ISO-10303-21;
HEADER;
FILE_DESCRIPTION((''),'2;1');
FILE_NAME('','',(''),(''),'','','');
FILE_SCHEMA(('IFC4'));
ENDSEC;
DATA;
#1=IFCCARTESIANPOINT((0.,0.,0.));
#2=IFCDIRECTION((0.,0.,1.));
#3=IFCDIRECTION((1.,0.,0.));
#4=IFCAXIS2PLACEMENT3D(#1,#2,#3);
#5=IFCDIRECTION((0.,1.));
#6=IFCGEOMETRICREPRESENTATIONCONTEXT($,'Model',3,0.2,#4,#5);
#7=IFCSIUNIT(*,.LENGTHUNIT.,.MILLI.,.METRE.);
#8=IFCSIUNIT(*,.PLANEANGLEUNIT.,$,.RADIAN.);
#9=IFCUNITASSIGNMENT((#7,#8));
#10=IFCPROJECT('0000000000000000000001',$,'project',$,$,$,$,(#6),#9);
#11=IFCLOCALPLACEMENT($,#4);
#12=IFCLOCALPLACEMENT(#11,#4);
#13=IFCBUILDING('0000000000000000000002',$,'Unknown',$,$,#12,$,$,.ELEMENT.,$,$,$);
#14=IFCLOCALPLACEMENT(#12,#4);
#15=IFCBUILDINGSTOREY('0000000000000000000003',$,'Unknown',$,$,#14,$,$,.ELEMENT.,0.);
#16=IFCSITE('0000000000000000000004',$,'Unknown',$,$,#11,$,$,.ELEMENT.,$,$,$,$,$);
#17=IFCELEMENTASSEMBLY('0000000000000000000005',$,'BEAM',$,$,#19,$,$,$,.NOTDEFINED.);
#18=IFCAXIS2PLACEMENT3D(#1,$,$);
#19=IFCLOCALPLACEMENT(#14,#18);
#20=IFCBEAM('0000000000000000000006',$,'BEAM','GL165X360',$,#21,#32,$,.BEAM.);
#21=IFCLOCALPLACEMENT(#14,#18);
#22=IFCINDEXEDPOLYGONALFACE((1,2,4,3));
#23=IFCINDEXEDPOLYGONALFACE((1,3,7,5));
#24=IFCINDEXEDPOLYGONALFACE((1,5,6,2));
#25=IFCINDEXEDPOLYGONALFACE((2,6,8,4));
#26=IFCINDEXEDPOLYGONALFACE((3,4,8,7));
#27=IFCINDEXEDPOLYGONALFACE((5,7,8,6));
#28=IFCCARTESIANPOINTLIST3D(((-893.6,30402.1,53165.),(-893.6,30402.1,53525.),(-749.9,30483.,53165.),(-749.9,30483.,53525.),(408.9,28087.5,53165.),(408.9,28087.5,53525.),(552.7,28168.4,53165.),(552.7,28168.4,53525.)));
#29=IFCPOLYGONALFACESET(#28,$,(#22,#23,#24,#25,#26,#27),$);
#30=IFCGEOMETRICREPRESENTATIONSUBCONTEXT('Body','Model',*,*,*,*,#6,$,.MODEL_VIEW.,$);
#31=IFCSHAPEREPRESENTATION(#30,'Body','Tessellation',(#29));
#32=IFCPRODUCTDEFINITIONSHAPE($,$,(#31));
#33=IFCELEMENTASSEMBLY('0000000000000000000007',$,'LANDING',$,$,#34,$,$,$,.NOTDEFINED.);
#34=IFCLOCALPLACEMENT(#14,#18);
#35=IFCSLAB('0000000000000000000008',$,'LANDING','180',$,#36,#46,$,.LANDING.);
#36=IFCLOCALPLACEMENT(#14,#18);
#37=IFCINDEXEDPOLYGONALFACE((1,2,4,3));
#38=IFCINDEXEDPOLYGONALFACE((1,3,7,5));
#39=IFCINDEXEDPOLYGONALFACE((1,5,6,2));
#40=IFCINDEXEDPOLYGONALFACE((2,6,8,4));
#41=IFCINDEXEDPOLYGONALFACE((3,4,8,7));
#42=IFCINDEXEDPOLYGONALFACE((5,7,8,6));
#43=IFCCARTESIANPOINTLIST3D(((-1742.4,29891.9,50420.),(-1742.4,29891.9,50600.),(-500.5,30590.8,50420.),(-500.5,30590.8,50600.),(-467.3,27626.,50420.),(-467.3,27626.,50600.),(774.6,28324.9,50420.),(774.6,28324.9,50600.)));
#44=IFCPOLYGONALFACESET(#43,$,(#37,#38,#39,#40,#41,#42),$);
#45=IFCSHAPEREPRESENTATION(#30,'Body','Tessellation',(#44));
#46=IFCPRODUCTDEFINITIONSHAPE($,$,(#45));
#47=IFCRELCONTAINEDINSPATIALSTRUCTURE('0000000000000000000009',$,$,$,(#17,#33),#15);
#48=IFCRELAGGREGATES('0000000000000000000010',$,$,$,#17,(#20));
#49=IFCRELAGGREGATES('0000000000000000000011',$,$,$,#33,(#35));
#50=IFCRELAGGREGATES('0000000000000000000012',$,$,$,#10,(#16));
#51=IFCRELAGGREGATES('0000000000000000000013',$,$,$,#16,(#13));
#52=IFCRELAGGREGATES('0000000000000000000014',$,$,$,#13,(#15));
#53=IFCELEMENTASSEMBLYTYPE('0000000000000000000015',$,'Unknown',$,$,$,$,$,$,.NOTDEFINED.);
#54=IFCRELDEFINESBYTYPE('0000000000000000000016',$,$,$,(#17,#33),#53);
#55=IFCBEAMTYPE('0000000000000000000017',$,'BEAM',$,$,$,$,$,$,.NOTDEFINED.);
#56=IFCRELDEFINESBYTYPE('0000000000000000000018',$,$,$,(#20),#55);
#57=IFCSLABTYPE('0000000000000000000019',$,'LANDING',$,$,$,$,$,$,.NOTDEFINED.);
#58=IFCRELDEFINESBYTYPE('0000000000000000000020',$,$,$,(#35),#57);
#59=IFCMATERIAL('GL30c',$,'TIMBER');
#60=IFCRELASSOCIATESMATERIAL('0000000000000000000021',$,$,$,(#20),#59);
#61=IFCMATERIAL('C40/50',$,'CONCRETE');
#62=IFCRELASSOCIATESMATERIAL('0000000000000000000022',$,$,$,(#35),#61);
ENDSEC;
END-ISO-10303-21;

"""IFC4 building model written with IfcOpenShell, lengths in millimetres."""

from ifc_helpers import new_model, si_unit, direction, frame, origin_with_axes, place, context, subcontext, project, spatial, polyline, line, indexed_curve, outline, extrude, material, material_profile, profile_set, profile_usage, type_object, element, aggregate, save


model = new_model("IFC4")

# Units and contexts
model_context = context("Model", 3, precision=0.2, world=origin_with_axes(), true_north=direction((0.0, 1.0)))
body_context = subcontext(model_context, "Body", "Model", "MODEL_VIEW")
ifc_project = project(units=[si_unit("LENGTHUNIT", "METRE", prefix="MILLI"), si_unit("PLANEANGLEUNIT", "RADIAN")], contexts=[model_context])

# Site, building, storey
site_placement = place(None, origin_with_axes())
site = spatial("IfcSite", under=ifc_project, at=site_placement, Name="Unknown", CompositionType="ELEMENT")
building_placement = place(site_placement, origin_with_axes())
building = spatial("IfcBuilding", under=site, at=building_placement, Name="Unknown", CompositionType="ELEMENT")
storey_placement = place(building_placement, origin_with_axes())
storey = spatial("IfcBuildingStorey", under=building, at=storey_placement, Name="Unknown", CompositionType="ELEMENT", Elevation=0.0)

# Shared definitions
element_assembly_type = type_object("IfcElementAssemblyType", Name="Unknown", PredefinedType="NOTDEFINED")
ifc_material_1 = material(Name="C40/50", Category="CONCRETE")

# Shared definitions
ifc_material_2 = material(Name="GL30c", Category="TIMBER")

# Element assembly, beam
ifc_material_profile_1 = material_profile(ifc_material_2, outline(polyline([(-82.5, 180.0), (-82.5, -180.0), (82.5, -180.0), (82.5, 180.0), (-82.5, 180.0)])), Name="GL165X360")
ifc_profile_set_1 = profile_set([ifc_material_profile_1])
ifc_profile_usage_1 = profile_usage(ifc_profile_set_1, cardinal=9)
beam_type_1 = type_object("IfcBeamType", Name="BEAM")
assembly_1_placement = place(storey_placement, frame((480.8, 28127.9, 53345.0), z_axis=(0.871484, 0.490423, 0.0), x_axis=(-0.490421, 0.871486, 0.0)))
assembly_1 = element("IfcElementAssembly", 1, at=assembly_1_placement, inside=storey, type_object=element_assembly_type, Name="BEAM", PredefinedType="NOTDEFINED")
beam_1_placement = place(assembly_1_placement, origin_with_axes())
beam_1 = element("IfcBeam", 2, at=beam_1_placement, type_object=beam_type_1, material=ifc_profile_usage_1, Name="BEAM", Description="GL165X360", PredefinedType="BEAM", context=body_context, shape_type="SolidModel", body=[
    extrude(outline(polyline([(-82.5, 180.0), (-82.5, -180.0), (82.5, -180.0), (82.5, 180.0), (-82.5, 180.0)])), frame((0.0, 0.0, 0.0), z_axis=(-1.0, 0.0, 0.0), x_axis=(0.0, 0.0, 1.0)), (0.0, 0.0, -1.0), 2656.0),
])
aggregate(assembly_1, [beam_1])

# Element assembly, slab
assembly_2_placement = place(storey_placement, frame((-500.5, 30590.8, 50510.0), z_axis=(0.0, 0.0, 1.0), x_axis=(-0.871485, -0.490422, 0.0)))
assembly_2 = element("IfcElementAssembly", 3, at=assembly_2_placement, inside=storey, type_object=element_assembly_type, Name="LANDING", PredefinedType="NOTDEFINED")
ifc_material_profile_2 = material_profile(ifc_material_1, outline(indexed_curve([(0.0, 0.0), (1425.0, 0.0), (1425.0, 2600.0), (0.0, 2600.0)], segments=[line(1, 2, 3, 4, 1)])), Name="180")
ifc_profile_set_2 = profile_set([ifc_material_profile_2])
ifc_profile_usage_2 = profile_usage(ifc_profile_set_2, cardinal=8)
slab_type = type_object("IfcSlabType", Name="LANDING")
slab_placement = place(assembly_2_placement, origin_with_axes())
slab = element("IfcSlab", 4, at=slab_placement, type_object=slab_type, material=ifc_profile_usage_2, Name="LANDING", Description="180", PredefinedType="LANDING", context=body_context, shape_type="SolidModel", body=[
    extrude(outline(indexed_curve([(0.0, 0.0), (1425.0, 0.0), (1425.0, 2600.0), (0.0, 2600.0)], segments=[line(1, 2, 3, 4, 1)])), frame((0.0, 0.0, 90.0), z_axis=(0.0, 0.0, 1.0), x_axis=(1.0, 0.0, 0.0)), (0.0, 0.0, -1.0), 180.0),
])
aggregate(assembly_2, [slab])

save(model, "model.ifc")
